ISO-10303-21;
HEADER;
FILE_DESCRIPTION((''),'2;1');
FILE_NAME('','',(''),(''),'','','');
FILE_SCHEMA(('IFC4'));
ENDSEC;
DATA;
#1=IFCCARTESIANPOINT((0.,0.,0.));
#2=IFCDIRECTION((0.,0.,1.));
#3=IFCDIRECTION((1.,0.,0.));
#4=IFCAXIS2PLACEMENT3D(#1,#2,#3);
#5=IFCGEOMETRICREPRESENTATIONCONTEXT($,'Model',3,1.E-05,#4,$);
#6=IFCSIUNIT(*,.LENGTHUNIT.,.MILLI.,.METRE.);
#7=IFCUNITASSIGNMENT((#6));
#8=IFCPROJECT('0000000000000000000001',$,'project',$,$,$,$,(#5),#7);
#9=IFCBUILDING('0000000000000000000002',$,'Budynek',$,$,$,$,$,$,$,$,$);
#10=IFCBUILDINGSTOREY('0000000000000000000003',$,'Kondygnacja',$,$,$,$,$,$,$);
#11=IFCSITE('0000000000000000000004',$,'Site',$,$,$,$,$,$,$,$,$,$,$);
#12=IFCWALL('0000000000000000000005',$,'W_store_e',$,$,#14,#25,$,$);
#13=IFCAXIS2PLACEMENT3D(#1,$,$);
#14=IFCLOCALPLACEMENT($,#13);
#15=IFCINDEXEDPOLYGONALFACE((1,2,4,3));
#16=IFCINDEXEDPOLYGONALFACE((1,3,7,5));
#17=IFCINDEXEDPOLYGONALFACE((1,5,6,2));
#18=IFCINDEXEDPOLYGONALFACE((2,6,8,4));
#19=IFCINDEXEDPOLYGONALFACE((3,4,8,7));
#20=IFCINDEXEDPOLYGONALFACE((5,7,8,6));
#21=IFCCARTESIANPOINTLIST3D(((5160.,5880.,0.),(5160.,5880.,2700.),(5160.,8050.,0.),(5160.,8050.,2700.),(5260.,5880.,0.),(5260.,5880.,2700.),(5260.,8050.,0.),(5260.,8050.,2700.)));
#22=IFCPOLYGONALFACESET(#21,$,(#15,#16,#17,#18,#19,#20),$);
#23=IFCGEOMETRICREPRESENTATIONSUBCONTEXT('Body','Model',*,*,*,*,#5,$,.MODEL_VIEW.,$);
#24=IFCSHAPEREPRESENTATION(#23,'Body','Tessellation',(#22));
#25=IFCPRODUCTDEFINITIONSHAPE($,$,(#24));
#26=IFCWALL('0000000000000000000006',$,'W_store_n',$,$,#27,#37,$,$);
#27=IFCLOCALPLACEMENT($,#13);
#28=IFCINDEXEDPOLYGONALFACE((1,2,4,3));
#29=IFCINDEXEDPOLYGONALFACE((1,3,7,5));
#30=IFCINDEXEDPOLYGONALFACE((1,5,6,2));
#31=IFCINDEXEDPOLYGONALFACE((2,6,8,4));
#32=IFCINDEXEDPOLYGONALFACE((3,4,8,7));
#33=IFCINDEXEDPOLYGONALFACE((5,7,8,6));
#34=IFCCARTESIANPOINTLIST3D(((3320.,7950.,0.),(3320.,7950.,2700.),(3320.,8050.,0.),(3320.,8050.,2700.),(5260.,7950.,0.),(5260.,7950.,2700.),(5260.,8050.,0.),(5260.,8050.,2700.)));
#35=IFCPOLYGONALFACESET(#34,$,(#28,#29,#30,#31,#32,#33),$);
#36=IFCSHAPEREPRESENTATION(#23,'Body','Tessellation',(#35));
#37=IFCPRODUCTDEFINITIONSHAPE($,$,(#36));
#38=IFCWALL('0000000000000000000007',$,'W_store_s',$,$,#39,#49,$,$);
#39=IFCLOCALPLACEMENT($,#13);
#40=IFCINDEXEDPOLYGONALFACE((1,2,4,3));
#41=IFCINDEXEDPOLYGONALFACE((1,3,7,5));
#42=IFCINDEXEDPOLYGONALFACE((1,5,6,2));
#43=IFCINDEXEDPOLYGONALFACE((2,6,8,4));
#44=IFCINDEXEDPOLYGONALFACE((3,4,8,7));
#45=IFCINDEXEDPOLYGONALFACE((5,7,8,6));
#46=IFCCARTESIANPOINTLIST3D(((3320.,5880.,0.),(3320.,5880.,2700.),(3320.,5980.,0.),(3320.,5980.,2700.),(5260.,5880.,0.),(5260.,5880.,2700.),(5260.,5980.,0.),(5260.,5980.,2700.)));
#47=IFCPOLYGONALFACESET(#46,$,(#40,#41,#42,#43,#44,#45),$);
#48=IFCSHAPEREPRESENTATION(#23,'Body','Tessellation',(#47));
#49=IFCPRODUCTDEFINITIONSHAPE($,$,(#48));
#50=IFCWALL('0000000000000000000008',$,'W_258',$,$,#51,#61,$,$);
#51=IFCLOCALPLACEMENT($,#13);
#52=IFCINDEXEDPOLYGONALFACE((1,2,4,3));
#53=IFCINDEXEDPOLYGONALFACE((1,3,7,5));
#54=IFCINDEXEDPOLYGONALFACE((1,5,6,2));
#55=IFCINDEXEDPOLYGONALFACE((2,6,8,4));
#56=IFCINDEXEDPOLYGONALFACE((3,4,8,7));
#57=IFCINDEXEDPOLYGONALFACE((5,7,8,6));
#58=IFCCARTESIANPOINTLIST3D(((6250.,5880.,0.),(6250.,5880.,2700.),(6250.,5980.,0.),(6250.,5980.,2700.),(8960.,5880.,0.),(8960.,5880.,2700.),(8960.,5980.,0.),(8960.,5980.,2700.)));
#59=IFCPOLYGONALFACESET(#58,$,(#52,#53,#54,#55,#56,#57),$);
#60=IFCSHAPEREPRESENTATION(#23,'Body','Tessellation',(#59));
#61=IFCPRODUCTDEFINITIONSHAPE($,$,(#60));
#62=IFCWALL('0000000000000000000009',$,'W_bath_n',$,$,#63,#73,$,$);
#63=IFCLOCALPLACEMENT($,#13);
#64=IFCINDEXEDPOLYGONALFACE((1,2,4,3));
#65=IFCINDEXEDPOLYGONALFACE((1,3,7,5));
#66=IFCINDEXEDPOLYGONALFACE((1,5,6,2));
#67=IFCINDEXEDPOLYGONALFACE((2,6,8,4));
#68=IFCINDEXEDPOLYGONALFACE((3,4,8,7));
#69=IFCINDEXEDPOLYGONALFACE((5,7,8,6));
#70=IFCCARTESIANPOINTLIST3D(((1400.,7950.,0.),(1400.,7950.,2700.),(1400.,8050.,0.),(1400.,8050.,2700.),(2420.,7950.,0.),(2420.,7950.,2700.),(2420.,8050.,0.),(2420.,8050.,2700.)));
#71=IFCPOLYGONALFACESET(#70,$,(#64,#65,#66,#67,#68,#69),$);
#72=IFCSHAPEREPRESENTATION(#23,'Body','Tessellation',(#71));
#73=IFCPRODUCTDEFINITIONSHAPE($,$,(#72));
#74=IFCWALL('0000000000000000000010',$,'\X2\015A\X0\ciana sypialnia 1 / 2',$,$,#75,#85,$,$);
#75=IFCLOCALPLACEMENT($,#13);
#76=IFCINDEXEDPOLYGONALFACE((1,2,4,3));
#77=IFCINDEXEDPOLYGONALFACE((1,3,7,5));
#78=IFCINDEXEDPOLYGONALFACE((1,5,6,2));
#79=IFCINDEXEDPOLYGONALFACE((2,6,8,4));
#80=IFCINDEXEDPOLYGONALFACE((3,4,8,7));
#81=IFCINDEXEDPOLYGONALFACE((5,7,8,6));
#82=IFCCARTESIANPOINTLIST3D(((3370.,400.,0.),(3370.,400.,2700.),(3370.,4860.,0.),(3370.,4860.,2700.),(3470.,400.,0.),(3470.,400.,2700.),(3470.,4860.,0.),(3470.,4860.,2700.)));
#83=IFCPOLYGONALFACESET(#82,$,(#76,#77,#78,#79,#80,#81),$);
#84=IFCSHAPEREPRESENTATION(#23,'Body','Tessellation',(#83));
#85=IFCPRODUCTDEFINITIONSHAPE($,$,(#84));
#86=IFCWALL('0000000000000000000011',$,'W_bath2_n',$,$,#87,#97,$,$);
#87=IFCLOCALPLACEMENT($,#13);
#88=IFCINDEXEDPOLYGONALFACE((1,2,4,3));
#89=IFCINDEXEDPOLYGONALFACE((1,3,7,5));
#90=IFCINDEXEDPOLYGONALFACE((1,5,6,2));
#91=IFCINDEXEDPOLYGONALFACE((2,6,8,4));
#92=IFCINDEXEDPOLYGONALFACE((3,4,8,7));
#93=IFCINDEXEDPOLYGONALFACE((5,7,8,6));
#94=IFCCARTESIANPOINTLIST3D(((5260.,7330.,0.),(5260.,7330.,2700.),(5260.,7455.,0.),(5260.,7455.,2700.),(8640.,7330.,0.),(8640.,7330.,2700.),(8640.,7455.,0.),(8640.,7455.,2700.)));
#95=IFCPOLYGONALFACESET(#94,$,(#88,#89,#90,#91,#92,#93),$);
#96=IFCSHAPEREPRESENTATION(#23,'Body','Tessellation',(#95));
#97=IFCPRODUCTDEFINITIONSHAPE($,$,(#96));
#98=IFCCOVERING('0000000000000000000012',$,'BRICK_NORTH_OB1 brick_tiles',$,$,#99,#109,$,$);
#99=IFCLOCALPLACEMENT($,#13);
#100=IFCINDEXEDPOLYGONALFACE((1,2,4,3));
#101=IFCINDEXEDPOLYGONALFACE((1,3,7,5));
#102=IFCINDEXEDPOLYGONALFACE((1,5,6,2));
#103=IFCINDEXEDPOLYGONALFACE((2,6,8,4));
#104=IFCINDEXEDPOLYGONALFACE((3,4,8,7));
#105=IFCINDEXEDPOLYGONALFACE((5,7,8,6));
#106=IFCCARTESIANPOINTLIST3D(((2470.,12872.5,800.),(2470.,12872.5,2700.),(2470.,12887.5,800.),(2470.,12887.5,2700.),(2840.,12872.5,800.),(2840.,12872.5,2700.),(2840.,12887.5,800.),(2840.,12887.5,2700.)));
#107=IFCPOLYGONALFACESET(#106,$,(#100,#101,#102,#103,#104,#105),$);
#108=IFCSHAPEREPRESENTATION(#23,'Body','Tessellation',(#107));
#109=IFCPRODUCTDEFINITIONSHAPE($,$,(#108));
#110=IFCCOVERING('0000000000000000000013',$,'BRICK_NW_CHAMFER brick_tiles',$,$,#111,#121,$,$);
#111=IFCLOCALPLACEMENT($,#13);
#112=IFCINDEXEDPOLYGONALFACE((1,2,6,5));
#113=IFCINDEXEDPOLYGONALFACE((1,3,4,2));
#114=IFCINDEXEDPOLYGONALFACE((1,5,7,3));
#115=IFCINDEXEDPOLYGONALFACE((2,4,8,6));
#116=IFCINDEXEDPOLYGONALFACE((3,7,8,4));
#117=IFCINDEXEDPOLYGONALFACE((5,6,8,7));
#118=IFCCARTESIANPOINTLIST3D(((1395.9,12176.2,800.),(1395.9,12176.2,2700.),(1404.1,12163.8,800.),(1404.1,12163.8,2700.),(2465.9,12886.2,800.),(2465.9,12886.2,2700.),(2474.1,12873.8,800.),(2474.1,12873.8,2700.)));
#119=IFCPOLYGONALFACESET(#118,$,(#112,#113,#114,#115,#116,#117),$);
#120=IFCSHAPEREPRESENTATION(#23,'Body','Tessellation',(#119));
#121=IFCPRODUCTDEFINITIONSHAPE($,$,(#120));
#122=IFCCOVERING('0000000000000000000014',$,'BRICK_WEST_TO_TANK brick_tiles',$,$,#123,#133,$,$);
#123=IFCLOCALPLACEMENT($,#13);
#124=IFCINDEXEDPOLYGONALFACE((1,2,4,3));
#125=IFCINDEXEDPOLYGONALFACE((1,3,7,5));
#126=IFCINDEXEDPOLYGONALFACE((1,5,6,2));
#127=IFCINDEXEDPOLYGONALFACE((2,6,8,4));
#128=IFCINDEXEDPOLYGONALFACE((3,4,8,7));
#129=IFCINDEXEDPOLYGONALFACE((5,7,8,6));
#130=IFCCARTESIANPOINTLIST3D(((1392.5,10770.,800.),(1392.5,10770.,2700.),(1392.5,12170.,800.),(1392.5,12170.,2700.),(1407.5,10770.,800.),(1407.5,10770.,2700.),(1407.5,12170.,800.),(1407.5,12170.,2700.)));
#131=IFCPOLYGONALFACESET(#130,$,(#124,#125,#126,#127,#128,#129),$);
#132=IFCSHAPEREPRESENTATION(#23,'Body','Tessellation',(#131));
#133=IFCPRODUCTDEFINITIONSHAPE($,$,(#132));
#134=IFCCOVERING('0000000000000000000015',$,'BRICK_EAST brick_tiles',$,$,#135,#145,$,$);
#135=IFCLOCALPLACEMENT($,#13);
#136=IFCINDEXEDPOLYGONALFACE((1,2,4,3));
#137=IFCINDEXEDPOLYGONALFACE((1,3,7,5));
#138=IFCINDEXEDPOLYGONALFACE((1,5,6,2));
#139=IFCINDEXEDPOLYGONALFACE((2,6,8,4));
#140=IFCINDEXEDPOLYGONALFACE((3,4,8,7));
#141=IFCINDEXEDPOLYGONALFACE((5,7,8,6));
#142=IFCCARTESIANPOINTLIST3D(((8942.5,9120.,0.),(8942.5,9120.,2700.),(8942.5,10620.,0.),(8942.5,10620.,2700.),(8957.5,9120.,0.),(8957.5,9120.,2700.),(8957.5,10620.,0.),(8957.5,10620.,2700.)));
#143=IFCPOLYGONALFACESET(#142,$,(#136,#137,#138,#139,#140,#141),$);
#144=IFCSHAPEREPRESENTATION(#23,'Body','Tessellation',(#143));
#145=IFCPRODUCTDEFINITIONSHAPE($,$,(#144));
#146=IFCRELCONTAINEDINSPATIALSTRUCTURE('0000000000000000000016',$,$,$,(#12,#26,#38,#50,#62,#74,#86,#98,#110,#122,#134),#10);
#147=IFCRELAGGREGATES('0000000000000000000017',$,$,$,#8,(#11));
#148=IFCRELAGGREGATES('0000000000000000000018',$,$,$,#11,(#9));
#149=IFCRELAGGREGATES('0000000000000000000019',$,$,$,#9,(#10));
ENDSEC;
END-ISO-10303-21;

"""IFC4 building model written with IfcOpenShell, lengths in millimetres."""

from ifc_helpers import new_model, si_unit, frame, origin_with_axes, place, context, subcontext, project, spatial, indexed_curve, outline, extrude, element, save


model = new_model("IFC4")

# Units and contexts
model_context = context("Model", 3, precision=1e-05, world=origin_with_axes())
body_context = subcontext(model_context, "Body", "Model", "MODEL_VIEW")
ifc_project = project(units=[si_unit("LENGTHUNIT", "METRE", prefix="MILLI")], contexts=[model_context])

# Site, building, storey
site = spatial("IfcSite", under=ifc_project, Name="Site")
building = spatial("IfcBuilding", under=site, Name="Budynek")
storey = spatial("IfcBuildingStorey", under=building, Name="Kondygnacja")

# Walls
wall_1_placement = place(None, frame((5210.0, 5880.0, 0.0), z_axis=(0.0, 0.0, 1.0), x_axis=(0.0, 1.0, 0.0)))
element("IfcWall", 1, at=wall_1_placement, inside=storey, Name="W_store_e", context=body_context, shape_type="SweptSolid", body=[
    extrude(outline(indexed_curve([(0.0, 0.0), (0.0, 100.0), (2170.0, 100.0), (2170.0, 0.0), (0.0, 0.0)], self_intersect=False)), frame((0.0, -50.0, 0.0), z_axis=(0.0, 0.0, 1.0), x_axis=(1.0, 0.0, 0.0)), (0.0, 0.0, 1.0), 2700.0),
])
for number, where, z_axis, x_axis, name in (
    (2, (3320.0, 8000.0, 0.0), (0.0, 0.0, 1.0), (1.0, 0.0, 0.0), "W_store_n"),
    (3, (3320.0, 5930.0, 0.0), (0.0, 0.0, 1.0), (1.0, 0.0, 0.0), "W_store_s"),
):
    element("IfcWall", number, at=place(None, frame(where, z_axis=z_axis, x_axis=x_axis)), inside=storey, Name=name, context=body_context, shape_type="SweptSolid", body=[
        extrude(outline(indexed_curve([(0.0, 0.0), (0.0, 100.0), (1940.0, 100.0), (1940.0, 0.0), (0.0, 0.0)], self_intersect=False)), frame((0.0, -50.0, 0.0), z_axis=(0.0, 0.0, 1.0), x_axis=(1.0, 0.0, 0.0)), (0.0, 0.0, 1.0), 2700.0),
    ])
wall_2_placement = place(None, frame((6250.0, 5930.0, 0.0), z_axis=(0.0, 0.0, 1.0), x_axis=(1.0, 0.0, 0.0)))
element("IfcWall", 4, at=wall_2_placement, inside=storey, Name="W_258", context=body_context, shape_type="SweptSolid", body=[
    extrude(outline(indexed_curve([(0.0, 0.0), (0.0, 100.0), (2710.0, 100.0), (2710.0, 0.0), (0.0, 0.0)], self_intersect=False)), frame((0.0, -50.0, 0.0), z_axis=(0.0, 0.0, 1.0), x_axis=(1.0, 0.0, 0.0)), (0.0, 0.0, 1.0), 2700.0),
])
wall_3_placement = place(None, frame((1400.0, 8000.0, 0.0), z_axis=(0.0, 0.0, 1.0), x_axis=(1.0, 0.0, 0.0)))
element("IfcWall", 5, at=wall_3_placement, inside=storey, Name="W_bath_n", context=body_context, shape_type="SweptSolid", body=[
    extrude(outline(indexed_curve([(0.0, 0.0), (0.0, 100.0), (1020.0, 100.0), (1020.0, 0.0), (0.0, 0.0)], self_intersect=False)), frame((0.0, -50.0, 0.0), z_axis=(0.0, 0.0, 1.0), x_axis=(1.0, 0.0, 0.0)), (0.0, 0.0, 1.0), 2700.0),
])
wall_4_placement = place(None, frame((3420.0, 400.0, 0.0), z_axis=(0.0, 0.0, 1.0), x_axis=(0.0, 1.0, 0.0)))
element("IfcWall", 6, at=wall_4_placement, inside=storey, Name="Ściana sypialnia 1 / 2", context=body_context, shape_type="SweptSolid", body=[
    extrude(outline(indexed_curve([(0.0, 0.0), (0.0, 100.0), (4460.0, 100.0), (4460.0, 0.0), (0.0, 0.0)], self_intersect=False)), frame((0.0, -50.0, 0.0), z_axis=(0.0, 0.0, 1.0), x_axis=(1.0, 0.0, 0.0)), (0.0, 0.0, 1.0), 2700.0),
])
wall_5_placement = place(None, frame((5260.0, 7392.5, 0.0), z_axis=(0.0, 0.0, 1.0), x_axis=(1.0, 0.0, 0.0)))
element("IfcWall", 7, at=wall_5_placement, inside=storey, Name="W_bath2_n", context=body_context, shape_type="SweptSolid", body=[
    extrude(outline(indexed_curve([(0.0, 0.0), (0.0, 125.0), (3380.0, 125.0), (3380.0, 0.0), (0.0, 0.0)], self_intersect=False)), frame((0.0, -62.5, 0.0), z_axis=(0.0, 0.0, 1.0), x_axis=(1.0, 0.0, 0.0)), (0.0, 0.0, 1.0), 2700.0),
])

# Coverings
covering_1_placement = place(None, frame((2840.0, 12880.0, 800.0), z_axis=(0.0, 0.0, 1.0), x_axis=(-1.0, 0.0, 0.0)))
element("IfcCovering", 8, at=covering_1_placement, inside=storey, Name="BRICK_NORTH_OB1 brick_tiles", context=body_context, shape_type="SweptSolid", body=[
    extrude(outline(indexed_curve([(0.0, 0.0), (0.0, 15.0), (370.0, 15.0), (370.0, 0.0), (0.0, 0.0)], self_intersect=False)), frame((0.0, -7.5, 0.0), z_axis=(0.0, 0.0, 1.0), x_axis=(1.0, 0.0, 0.0)), (0.0, 0.0, 1.0), 1900.0),
])
covering_2_placement = place(None, frame((2470.0, 12880.0, 800.0), z_axis=(0.0, 0.0, 1.0), x_axis=(-0.833246, -0.552902, 0.0)))
element("IfcCovering", 9, at=covering_2_placement, inside=storey, Name="BRICK_NW_CHAMFER brick_tiles", context=body_context, shape_type="SweptSolid", body=[
    extrude(outline(indexed_curve([(0.0, 0.0), (0.0, 15.0), (1284.1, 15.0), (1284.1, 0.0), (0.0, 0.0)], self_intersect=False)), frame((0.0, -7.5, 0.0), z_axis=(0.0, 0.0, 1.0), x_axis=(1.0, 0.0, 0.0)), (0.0, 0.0, 1.0), 1900.0),
])
covering_3_placement = place(None, frame((1400.0, 12170.0, 800.0), z_axis=(0.0, 0.0, 1.0), x_axis=(0.0, -1.0, 0.0)))
element("IfcCovering", 10, at=covering_3_placement, inside=storey, Name="BRICK_WEST_TO_TANK brick_tiles", context=body_context, shape_type="SweptSolid", body=[
    extrude(outline(indexed_curve([(0.0, 0.0), (0.0, 15.0), (1400.0, 15.0), (1400.0, 0.0), (0.0, 0.0)], self_intersect=False)), frame((0.0, -7.5, 0.0), z_axis=(0.0, 0.0, 1.0), x_axis=(1.0, 0.0, 0.0)), (0.0, 0.0, 1.0), 1900.0),
])
covering_4_placement = place(None, frame((8950.0, 9120.0, 0.0), z_axis=(0.0, 0.0, 1.0), x_axis=(0.0, 1.0, 0.0)))
element("IfcCovering", 11, at=covering_4_placement, inside=storey, Name="BRICK_EAST brick_tiles", context=body_context, shape_type="SweptSolid", body=[
    extrude(outline(indexed_curve([(0.0, 0.0), (0.0, 15.0), (1500.0, 15.0), (1500.0, 0.0), (0.0, 0.0)], self_intersect=False)), frame((0.0, -7.5, 0.0), z_axis=(0.0, 0.0, 1.0), x_axis=(1.0, 0.0, 0.0)), (0.0, 0.0, 1.0), 2700.0),
])

save(model, "model.ifc")
